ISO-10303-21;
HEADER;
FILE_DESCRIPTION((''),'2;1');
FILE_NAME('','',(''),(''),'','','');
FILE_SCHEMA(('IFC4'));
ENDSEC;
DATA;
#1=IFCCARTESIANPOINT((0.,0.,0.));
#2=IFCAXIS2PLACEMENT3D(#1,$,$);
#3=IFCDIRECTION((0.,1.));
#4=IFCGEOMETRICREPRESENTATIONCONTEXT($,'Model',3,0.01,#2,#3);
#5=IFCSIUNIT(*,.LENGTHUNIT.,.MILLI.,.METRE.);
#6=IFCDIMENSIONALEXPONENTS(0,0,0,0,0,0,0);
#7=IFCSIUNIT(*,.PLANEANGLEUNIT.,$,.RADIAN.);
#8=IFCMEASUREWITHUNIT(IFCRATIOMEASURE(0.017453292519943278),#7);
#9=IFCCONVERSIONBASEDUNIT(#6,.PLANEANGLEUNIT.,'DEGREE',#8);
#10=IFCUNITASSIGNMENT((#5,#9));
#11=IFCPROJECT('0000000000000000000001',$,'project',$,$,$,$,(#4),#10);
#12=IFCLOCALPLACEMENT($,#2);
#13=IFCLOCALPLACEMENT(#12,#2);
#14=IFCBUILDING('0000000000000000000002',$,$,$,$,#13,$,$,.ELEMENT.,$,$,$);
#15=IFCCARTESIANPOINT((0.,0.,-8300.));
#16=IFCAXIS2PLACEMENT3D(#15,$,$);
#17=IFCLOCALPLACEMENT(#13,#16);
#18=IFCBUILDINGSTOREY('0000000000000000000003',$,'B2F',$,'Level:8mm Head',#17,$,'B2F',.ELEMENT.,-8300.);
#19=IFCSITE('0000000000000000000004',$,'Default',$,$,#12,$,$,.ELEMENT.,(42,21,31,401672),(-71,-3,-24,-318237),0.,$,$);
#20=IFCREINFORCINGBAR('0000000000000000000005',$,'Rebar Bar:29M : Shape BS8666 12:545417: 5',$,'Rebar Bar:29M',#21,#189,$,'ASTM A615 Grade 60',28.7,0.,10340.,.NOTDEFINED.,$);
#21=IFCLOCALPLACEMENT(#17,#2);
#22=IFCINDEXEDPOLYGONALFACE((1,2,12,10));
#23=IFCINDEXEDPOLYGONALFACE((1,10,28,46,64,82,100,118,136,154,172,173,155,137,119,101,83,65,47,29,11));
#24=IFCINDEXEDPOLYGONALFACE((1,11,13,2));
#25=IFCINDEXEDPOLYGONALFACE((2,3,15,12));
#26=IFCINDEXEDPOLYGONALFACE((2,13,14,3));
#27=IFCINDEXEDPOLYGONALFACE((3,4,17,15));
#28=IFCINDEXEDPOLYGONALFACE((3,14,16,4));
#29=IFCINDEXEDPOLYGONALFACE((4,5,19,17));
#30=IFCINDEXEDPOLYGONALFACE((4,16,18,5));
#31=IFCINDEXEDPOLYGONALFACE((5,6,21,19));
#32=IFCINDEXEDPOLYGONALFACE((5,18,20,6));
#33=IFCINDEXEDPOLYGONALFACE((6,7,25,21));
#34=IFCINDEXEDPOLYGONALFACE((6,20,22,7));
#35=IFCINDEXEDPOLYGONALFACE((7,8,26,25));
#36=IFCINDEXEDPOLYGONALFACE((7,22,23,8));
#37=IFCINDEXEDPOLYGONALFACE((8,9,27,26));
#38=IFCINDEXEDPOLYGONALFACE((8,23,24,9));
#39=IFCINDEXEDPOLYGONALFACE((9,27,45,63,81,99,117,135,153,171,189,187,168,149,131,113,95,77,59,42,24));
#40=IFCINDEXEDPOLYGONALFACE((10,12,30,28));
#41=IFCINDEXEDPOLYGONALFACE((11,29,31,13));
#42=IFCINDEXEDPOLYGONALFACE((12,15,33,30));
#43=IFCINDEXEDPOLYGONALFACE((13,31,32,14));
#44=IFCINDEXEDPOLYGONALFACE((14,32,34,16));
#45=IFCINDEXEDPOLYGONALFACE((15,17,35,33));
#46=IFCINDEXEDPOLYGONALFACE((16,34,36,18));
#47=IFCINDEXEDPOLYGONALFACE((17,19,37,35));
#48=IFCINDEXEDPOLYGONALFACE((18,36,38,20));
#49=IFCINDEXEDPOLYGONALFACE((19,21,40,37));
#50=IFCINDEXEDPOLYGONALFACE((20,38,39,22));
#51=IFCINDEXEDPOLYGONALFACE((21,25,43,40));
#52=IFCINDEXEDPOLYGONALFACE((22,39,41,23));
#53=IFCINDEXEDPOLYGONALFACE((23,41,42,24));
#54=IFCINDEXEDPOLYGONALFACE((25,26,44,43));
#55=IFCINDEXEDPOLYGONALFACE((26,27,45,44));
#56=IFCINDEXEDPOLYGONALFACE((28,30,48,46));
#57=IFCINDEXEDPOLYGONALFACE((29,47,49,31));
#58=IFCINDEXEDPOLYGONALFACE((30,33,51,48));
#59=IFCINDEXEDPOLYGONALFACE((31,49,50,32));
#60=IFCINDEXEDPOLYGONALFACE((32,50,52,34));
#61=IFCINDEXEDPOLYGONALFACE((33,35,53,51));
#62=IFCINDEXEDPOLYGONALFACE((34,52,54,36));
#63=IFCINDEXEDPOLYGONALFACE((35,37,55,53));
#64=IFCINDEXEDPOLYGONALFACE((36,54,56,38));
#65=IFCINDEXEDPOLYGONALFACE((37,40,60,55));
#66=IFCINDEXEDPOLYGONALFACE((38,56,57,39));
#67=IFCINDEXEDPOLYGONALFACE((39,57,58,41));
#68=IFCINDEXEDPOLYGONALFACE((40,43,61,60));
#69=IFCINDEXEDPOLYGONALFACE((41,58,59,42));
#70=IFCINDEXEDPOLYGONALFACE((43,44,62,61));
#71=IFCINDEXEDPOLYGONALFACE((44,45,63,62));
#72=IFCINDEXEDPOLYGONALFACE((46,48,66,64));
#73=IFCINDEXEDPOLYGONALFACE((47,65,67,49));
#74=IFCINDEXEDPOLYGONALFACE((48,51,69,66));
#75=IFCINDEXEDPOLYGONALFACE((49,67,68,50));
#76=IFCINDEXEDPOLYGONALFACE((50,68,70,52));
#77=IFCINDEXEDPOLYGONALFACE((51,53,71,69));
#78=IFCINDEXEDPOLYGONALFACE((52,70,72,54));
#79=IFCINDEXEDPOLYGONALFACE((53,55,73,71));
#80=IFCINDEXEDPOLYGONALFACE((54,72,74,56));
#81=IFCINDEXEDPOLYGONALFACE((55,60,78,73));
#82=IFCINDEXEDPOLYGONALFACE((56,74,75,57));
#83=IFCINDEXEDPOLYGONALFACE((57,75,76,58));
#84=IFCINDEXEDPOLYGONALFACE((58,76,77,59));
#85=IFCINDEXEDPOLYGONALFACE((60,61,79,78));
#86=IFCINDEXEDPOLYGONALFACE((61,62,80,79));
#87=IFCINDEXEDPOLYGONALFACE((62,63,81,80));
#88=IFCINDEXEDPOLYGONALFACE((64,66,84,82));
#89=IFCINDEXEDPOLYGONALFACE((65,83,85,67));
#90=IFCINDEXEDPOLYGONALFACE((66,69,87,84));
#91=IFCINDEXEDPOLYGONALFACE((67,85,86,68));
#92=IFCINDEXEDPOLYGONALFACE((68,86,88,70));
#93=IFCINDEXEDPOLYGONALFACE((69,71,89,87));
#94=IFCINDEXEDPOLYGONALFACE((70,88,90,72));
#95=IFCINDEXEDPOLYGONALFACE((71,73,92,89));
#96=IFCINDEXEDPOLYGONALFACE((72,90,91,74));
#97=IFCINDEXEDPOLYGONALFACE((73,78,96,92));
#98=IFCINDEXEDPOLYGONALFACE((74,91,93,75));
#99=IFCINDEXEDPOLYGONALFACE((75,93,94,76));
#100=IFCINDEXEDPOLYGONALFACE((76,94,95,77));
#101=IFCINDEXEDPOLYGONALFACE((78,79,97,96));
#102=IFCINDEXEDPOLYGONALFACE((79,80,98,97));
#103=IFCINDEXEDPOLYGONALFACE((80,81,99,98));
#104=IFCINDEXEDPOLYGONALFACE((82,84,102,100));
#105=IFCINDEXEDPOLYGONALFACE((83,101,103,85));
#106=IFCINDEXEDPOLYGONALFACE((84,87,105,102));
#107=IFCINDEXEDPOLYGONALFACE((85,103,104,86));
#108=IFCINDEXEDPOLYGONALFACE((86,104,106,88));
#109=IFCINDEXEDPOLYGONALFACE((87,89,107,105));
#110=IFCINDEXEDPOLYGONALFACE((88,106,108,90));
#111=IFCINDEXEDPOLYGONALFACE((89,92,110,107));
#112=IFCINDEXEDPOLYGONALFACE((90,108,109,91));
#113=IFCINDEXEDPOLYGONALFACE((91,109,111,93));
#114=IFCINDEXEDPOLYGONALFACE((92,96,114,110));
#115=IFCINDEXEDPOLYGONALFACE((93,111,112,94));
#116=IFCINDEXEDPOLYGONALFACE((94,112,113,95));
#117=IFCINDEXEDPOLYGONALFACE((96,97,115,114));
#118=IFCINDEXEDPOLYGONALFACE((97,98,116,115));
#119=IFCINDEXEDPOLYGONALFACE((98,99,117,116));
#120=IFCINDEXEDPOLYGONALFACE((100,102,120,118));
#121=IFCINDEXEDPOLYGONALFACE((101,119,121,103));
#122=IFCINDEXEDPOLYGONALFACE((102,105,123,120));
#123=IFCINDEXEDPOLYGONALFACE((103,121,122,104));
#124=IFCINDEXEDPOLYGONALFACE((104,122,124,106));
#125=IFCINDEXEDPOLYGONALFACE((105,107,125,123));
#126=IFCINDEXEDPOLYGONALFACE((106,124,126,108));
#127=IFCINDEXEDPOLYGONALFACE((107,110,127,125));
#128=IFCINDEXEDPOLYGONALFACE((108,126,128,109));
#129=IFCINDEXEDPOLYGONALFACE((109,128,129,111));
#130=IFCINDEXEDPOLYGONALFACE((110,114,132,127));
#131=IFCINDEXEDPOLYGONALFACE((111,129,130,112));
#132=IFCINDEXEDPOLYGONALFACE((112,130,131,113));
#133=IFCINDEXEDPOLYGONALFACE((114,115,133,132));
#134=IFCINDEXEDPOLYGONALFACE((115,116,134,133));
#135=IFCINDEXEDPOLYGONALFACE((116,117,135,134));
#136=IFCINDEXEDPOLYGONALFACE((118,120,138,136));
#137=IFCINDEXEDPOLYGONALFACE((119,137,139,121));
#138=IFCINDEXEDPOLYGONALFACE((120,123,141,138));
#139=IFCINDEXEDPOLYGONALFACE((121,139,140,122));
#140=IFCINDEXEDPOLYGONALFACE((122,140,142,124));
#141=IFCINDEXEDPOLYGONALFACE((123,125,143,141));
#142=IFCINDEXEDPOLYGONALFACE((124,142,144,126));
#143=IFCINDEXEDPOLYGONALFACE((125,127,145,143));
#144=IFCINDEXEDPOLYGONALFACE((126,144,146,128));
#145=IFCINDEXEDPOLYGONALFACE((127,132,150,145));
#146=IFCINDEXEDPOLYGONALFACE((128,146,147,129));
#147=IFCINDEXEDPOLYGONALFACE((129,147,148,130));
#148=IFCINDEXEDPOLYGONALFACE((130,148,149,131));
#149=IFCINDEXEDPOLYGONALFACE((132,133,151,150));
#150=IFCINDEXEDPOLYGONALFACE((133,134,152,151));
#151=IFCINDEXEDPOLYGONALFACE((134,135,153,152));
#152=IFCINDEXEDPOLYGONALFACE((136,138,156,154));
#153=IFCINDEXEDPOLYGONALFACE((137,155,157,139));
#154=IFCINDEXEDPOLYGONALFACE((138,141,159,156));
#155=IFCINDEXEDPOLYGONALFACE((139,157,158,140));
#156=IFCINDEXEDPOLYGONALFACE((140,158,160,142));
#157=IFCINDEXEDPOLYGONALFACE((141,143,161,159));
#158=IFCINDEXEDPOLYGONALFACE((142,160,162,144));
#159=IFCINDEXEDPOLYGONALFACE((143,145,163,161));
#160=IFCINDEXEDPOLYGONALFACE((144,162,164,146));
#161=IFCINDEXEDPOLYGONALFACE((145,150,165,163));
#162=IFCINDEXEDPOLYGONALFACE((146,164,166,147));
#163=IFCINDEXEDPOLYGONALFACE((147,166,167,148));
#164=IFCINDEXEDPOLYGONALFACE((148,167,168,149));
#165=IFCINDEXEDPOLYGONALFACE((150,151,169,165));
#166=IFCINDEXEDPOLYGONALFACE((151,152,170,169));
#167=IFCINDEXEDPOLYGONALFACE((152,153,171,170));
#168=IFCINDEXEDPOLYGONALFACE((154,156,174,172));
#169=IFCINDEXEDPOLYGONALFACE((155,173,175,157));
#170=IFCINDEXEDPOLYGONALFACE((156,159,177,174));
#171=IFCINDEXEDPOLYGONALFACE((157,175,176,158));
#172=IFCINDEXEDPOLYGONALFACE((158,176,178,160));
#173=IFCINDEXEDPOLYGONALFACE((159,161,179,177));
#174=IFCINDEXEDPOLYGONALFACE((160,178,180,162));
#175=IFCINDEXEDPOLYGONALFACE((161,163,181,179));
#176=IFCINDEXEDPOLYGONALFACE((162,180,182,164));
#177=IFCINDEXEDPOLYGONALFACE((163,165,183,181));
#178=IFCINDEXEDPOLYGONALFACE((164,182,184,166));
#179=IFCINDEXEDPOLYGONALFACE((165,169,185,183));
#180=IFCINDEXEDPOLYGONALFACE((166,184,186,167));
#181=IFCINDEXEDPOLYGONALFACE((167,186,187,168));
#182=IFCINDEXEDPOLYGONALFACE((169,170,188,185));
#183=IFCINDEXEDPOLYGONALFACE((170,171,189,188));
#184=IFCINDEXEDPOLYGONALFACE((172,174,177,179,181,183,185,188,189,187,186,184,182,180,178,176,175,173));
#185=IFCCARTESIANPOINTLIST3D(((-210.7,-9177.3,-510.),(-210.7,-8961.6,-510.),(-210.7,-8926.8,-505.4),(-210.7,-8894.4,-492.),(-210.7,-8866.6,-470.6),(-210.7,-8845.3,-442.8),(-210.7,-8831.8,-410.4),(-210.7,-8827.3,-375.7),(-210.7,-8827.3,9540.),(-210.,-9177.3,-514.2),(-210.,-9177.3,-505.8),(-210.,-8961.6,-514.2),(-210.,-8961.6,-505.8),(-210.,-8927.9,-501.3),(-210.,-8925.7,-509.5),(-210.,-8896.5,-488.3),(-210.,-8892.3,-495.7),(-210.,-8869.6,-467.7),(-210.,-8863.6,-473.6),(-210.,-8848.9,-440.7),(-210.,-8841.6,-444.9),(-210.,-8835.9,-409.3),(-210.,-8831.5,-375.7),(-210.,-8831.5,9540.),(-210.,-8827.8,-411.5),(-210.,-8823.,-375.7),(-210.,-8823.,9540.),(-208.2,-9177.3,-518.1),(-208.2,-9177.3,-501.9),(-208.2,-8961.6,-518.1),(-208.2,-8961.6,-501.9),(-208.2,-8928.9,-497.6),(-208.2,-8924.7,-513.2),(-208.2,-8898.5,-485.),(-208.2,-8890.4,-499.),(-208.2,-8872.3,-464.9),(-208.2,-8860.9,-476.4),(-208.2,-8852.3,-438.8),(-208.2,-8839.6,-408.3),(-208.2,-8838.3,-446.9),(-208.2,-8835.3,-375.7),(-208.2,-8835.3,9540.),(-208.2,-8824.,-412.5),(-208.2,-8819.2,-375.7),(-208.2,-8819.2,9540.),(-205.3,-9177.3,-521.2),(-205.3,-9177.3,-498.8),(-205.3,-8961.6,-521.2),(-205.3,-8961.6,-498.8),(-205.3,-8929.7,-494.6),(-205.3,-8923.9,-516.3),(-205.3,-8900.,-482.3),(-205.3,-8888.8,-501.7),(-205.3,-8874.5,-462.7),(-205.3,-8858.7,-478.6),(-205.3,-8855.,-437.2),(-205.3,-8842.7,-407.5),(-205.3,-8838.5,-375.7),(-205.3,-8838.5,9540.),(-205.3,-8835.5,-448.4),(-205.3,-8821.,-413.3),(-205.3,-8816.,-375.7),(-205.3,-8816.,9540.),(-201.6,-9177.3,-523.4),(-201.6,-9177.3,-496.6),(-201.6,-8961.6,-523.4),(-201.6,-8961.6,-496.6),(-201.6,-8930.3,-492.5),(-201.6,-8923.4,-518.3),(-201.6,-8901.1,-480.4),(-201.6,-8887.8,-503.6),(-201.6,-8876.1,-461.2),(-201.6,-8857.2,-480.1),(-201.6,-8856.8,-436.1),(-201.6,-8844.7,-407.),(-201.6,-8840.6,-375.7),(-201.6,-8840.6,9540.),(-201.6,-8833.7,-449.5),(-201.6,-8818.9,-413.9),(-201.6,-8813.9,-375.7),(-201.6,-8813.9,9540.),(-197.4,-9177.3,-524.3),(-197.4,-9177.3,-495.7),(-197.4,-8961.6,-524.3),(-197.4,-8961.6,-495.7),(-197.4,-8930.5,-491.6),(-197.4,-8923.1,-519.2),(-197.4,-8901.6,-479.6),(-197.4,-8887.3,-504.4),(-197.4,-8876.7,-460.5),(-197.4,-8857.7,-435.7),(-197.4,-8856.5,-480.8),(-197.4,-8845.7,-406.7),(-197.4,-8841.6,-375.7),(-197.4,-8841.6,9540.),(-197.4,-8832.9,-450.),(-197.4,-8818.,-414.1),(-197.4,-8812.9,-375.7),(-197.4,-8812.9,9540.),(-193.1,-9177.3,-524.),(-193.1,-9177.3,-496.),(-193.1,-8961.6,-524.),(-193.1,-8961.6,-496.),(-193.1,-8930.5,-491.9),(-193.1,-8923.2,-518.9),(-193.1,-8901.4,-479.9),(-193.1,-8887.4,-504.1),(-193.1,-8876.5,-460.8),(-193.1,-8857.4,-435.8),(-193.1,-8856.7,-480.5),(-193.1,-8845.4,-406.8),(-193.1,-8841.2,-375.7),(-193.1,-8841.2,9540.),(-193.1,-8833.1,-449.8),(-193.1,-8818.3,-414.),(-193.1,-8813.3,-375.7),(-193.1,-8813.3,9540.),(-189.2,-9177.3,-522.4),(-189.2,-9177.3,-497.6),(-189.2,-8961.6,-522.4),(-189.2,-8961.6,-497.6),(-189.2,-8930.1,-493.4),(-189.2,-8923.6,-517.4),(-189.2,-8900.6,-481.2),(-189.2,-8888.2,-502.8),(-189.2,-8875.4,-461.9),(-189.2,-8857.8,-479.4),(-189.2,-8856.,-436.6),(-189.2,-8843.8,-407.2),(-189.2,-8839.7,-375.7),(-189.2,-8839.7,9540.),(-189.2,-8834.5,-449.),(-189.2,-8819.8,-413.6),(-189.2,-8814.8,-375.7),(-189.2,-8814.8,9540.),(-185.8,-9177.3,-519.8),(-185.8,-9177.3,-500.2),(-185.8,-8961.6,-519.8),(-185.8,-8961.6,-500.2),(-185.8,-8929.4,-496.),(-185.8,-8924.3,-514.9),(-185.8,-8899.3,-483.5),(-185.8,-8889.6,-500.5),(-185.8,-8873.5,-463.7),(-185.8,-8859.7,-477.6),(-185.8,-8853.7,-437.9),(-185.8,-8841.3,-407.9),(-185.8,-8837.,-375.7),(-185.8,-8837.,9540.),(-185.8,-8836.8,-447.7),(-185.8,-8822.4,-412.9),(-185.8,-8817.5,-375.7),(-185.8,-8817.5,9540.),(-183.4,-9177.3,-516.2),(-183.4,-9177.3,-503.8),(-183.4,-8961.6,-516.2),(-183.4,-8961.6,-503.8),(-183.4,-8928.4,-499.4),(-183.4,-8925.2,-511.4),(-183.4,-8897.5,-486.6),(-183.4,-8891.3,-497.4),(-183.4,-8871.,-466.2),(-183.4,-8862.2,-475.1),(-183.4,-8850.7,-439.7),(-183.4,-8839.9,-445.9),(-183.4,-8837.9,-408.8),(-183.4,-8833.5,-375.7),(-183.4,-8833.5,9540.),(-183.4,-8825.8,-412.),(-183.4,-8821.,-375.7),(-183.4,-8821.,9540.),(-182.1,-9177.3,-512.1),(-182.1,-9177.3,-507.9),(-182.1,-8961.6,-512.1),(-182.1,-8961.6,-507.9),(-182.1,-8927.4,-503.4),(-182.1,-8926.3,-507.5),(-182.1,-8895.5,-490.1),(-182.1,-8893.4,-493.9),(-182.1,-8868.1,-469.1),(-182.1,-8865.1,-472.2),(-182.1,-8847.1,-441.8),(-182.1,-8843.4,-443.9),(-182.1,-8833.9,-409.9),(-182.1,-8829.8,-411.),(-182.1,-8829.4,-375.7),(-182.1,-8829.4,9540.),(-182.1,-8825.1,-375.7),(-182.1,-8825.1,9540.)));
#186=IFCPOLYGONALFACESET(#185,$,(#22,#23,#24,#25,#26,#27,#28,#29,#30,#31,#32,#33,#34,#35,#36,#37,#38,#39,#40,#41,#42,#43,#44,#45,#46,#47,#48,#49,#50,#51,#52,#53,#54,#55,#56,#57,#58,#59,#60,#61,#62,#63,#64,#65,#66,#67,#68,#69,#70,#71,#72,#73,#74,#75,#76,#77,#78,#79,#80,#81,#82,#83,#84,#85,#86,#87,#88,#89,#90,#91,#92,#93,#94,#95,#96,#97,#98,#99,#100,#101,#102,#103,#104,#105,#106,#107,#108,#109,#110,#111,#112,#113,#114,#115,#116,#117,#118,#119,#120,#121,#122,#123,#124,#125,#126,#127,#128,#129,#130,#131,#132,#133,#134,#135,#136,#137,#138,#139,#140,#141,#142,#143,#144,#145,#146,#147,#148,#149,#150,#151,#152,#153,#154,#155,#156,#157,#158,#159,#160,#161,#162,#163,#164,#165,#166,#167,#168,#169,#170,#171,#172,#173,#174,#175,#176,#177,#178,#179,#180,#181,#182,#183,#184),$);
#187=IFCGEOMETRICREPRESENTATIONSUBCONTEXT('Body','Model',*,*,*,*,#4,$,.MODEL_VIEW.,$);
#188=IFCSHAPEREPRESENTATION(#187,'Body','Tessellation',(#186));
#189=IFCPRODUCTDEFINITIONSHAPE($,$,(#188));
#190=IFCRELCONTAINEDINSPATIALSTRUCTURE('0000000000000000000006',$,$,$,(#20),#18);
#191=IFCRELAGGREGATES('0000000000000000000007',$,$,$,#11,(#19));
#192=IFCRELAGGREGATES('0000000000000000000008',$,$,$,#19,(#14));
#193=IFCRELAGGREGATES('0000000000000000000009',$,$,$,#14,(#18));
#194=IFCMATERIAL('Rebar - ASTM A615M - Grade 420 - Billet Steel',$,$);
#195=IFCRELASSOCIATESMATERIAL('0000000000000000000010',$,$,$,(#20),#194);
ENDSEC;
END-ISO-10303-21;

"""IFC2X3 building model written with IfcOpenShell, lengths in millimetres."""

from ifc_helpers import new_model, entity, si_unit, converted_unit, direction, frame, origin, place, context, subcontext, project, spatial, material, element, save


model = new_model("IFC2X3")

# Units and contexts
model_context = context("Model", 3, precision=0.01, world=origin(), true_north=direction((0.0, 1.0)))
body_context = subcontext(model_context, "Body", "Model", "MODEL_VIEW")
ifc_project = project(units=[si_unit("LENGTHUNIT", "METRE", prefix="MILLI"), converted_unit("PLANEANGLEUNIT", "DEGREE", entity("IfcRatioMeasure", 0.017453292519943278), si_unit("PLANEANGLEUNIT", "RADIAN"), dimensions=[0, 0, 0, 0, 0, 0, 0])], contexts=[model_context])

# Site, building, storey
site_placement = place(None, origin())
site = spatial("IfcSite", under=ifc_project, at=site_placement, Name="Default", CompositionType="ELEMENT", RefLatitude=(42, 21, 31, 401672), RefLongitude=(-71, -3, -24, -318237), RefElevation=0.0)
building_placement = place(site_placement, origin())
building = spatial("IfcBuilding", under=site, at=building_placement, CompositionType="ELEMENT")
storey_placement = place(building_placement, frame((0.0, 0.0, -8300.0)))
storey = spatial("IfcBuildingStorey", under=building, at=storey_placement, Name="B2F", ObjectType="Level:8mm Head", LongName="B2F", CompositionType="ELEMENT", Elevation=-8300.0)

# Reinforcing bar
ifc_material_1 = material(Name="Rebar - ASTM A615M - Grade 420 - Billet Steel")
reinforcing_bar_1_placement = place(storey_placement, origin())
element("IfcReinforcingBar", 1, at=reinforcing_bar_1_placement, inside=storey, material=ifc_material_1, Name="Rebar Bar:29M : Shape BS8666 12:545417: 5", SteelGrade="ASTM A615 Grade 60", ObjectType="Rebar Bar:29M", BarLength=10340.0, BarRole="NOTDEFINED", CrossSectionArea=0.0, NominalDiameter=28.7, context=body_context, shape_type="AdvancedSweptSolid", body=[
    entity("IfcSweptDiskSolid", entity("IfcCompositeCurve", [entity("IfcCompositeCurveSegment", "CONTINUOUS", True, entity("IfcPolyline", [entity("IfcCartesianPoint", [-196.3, -8827.3, 9540.0]), entity("IfcCartesianPoint", [-196.3, -8827.3, -375.7])])), entity("IfcCompositeCurveSegment", "CONTINUOUS", True, entity("IfcTrimmedCurve", entity("IfcCircle", entity("IfcAxis2Placement3D", entity("IfcCartesianPoint", [-196.3, -8961.6, -375.7]), entity("IfcDirection", [-1.0, 0.0, 0.0]), entity("IfcDirection", [0.0, 0.0, -1.0])), 134.3), [entity("IfcParameterValue", 270.0)], [entity("IfcParameterValue", 360.0)], True, "PARAMETER")), entity("IfcCompositeCurveSegment", "CONTINUOUS", True, entity("IfcPolyline", [entity("IfcCartesianPoint", [-196.3, -8961.6, -510.0]), entity("IfcCartesianPoint", [-196.3, -9177.3, -510.0])]))], False), 14.3, None, 0.0, 92.0),
])

save(model, "model.ifc")
